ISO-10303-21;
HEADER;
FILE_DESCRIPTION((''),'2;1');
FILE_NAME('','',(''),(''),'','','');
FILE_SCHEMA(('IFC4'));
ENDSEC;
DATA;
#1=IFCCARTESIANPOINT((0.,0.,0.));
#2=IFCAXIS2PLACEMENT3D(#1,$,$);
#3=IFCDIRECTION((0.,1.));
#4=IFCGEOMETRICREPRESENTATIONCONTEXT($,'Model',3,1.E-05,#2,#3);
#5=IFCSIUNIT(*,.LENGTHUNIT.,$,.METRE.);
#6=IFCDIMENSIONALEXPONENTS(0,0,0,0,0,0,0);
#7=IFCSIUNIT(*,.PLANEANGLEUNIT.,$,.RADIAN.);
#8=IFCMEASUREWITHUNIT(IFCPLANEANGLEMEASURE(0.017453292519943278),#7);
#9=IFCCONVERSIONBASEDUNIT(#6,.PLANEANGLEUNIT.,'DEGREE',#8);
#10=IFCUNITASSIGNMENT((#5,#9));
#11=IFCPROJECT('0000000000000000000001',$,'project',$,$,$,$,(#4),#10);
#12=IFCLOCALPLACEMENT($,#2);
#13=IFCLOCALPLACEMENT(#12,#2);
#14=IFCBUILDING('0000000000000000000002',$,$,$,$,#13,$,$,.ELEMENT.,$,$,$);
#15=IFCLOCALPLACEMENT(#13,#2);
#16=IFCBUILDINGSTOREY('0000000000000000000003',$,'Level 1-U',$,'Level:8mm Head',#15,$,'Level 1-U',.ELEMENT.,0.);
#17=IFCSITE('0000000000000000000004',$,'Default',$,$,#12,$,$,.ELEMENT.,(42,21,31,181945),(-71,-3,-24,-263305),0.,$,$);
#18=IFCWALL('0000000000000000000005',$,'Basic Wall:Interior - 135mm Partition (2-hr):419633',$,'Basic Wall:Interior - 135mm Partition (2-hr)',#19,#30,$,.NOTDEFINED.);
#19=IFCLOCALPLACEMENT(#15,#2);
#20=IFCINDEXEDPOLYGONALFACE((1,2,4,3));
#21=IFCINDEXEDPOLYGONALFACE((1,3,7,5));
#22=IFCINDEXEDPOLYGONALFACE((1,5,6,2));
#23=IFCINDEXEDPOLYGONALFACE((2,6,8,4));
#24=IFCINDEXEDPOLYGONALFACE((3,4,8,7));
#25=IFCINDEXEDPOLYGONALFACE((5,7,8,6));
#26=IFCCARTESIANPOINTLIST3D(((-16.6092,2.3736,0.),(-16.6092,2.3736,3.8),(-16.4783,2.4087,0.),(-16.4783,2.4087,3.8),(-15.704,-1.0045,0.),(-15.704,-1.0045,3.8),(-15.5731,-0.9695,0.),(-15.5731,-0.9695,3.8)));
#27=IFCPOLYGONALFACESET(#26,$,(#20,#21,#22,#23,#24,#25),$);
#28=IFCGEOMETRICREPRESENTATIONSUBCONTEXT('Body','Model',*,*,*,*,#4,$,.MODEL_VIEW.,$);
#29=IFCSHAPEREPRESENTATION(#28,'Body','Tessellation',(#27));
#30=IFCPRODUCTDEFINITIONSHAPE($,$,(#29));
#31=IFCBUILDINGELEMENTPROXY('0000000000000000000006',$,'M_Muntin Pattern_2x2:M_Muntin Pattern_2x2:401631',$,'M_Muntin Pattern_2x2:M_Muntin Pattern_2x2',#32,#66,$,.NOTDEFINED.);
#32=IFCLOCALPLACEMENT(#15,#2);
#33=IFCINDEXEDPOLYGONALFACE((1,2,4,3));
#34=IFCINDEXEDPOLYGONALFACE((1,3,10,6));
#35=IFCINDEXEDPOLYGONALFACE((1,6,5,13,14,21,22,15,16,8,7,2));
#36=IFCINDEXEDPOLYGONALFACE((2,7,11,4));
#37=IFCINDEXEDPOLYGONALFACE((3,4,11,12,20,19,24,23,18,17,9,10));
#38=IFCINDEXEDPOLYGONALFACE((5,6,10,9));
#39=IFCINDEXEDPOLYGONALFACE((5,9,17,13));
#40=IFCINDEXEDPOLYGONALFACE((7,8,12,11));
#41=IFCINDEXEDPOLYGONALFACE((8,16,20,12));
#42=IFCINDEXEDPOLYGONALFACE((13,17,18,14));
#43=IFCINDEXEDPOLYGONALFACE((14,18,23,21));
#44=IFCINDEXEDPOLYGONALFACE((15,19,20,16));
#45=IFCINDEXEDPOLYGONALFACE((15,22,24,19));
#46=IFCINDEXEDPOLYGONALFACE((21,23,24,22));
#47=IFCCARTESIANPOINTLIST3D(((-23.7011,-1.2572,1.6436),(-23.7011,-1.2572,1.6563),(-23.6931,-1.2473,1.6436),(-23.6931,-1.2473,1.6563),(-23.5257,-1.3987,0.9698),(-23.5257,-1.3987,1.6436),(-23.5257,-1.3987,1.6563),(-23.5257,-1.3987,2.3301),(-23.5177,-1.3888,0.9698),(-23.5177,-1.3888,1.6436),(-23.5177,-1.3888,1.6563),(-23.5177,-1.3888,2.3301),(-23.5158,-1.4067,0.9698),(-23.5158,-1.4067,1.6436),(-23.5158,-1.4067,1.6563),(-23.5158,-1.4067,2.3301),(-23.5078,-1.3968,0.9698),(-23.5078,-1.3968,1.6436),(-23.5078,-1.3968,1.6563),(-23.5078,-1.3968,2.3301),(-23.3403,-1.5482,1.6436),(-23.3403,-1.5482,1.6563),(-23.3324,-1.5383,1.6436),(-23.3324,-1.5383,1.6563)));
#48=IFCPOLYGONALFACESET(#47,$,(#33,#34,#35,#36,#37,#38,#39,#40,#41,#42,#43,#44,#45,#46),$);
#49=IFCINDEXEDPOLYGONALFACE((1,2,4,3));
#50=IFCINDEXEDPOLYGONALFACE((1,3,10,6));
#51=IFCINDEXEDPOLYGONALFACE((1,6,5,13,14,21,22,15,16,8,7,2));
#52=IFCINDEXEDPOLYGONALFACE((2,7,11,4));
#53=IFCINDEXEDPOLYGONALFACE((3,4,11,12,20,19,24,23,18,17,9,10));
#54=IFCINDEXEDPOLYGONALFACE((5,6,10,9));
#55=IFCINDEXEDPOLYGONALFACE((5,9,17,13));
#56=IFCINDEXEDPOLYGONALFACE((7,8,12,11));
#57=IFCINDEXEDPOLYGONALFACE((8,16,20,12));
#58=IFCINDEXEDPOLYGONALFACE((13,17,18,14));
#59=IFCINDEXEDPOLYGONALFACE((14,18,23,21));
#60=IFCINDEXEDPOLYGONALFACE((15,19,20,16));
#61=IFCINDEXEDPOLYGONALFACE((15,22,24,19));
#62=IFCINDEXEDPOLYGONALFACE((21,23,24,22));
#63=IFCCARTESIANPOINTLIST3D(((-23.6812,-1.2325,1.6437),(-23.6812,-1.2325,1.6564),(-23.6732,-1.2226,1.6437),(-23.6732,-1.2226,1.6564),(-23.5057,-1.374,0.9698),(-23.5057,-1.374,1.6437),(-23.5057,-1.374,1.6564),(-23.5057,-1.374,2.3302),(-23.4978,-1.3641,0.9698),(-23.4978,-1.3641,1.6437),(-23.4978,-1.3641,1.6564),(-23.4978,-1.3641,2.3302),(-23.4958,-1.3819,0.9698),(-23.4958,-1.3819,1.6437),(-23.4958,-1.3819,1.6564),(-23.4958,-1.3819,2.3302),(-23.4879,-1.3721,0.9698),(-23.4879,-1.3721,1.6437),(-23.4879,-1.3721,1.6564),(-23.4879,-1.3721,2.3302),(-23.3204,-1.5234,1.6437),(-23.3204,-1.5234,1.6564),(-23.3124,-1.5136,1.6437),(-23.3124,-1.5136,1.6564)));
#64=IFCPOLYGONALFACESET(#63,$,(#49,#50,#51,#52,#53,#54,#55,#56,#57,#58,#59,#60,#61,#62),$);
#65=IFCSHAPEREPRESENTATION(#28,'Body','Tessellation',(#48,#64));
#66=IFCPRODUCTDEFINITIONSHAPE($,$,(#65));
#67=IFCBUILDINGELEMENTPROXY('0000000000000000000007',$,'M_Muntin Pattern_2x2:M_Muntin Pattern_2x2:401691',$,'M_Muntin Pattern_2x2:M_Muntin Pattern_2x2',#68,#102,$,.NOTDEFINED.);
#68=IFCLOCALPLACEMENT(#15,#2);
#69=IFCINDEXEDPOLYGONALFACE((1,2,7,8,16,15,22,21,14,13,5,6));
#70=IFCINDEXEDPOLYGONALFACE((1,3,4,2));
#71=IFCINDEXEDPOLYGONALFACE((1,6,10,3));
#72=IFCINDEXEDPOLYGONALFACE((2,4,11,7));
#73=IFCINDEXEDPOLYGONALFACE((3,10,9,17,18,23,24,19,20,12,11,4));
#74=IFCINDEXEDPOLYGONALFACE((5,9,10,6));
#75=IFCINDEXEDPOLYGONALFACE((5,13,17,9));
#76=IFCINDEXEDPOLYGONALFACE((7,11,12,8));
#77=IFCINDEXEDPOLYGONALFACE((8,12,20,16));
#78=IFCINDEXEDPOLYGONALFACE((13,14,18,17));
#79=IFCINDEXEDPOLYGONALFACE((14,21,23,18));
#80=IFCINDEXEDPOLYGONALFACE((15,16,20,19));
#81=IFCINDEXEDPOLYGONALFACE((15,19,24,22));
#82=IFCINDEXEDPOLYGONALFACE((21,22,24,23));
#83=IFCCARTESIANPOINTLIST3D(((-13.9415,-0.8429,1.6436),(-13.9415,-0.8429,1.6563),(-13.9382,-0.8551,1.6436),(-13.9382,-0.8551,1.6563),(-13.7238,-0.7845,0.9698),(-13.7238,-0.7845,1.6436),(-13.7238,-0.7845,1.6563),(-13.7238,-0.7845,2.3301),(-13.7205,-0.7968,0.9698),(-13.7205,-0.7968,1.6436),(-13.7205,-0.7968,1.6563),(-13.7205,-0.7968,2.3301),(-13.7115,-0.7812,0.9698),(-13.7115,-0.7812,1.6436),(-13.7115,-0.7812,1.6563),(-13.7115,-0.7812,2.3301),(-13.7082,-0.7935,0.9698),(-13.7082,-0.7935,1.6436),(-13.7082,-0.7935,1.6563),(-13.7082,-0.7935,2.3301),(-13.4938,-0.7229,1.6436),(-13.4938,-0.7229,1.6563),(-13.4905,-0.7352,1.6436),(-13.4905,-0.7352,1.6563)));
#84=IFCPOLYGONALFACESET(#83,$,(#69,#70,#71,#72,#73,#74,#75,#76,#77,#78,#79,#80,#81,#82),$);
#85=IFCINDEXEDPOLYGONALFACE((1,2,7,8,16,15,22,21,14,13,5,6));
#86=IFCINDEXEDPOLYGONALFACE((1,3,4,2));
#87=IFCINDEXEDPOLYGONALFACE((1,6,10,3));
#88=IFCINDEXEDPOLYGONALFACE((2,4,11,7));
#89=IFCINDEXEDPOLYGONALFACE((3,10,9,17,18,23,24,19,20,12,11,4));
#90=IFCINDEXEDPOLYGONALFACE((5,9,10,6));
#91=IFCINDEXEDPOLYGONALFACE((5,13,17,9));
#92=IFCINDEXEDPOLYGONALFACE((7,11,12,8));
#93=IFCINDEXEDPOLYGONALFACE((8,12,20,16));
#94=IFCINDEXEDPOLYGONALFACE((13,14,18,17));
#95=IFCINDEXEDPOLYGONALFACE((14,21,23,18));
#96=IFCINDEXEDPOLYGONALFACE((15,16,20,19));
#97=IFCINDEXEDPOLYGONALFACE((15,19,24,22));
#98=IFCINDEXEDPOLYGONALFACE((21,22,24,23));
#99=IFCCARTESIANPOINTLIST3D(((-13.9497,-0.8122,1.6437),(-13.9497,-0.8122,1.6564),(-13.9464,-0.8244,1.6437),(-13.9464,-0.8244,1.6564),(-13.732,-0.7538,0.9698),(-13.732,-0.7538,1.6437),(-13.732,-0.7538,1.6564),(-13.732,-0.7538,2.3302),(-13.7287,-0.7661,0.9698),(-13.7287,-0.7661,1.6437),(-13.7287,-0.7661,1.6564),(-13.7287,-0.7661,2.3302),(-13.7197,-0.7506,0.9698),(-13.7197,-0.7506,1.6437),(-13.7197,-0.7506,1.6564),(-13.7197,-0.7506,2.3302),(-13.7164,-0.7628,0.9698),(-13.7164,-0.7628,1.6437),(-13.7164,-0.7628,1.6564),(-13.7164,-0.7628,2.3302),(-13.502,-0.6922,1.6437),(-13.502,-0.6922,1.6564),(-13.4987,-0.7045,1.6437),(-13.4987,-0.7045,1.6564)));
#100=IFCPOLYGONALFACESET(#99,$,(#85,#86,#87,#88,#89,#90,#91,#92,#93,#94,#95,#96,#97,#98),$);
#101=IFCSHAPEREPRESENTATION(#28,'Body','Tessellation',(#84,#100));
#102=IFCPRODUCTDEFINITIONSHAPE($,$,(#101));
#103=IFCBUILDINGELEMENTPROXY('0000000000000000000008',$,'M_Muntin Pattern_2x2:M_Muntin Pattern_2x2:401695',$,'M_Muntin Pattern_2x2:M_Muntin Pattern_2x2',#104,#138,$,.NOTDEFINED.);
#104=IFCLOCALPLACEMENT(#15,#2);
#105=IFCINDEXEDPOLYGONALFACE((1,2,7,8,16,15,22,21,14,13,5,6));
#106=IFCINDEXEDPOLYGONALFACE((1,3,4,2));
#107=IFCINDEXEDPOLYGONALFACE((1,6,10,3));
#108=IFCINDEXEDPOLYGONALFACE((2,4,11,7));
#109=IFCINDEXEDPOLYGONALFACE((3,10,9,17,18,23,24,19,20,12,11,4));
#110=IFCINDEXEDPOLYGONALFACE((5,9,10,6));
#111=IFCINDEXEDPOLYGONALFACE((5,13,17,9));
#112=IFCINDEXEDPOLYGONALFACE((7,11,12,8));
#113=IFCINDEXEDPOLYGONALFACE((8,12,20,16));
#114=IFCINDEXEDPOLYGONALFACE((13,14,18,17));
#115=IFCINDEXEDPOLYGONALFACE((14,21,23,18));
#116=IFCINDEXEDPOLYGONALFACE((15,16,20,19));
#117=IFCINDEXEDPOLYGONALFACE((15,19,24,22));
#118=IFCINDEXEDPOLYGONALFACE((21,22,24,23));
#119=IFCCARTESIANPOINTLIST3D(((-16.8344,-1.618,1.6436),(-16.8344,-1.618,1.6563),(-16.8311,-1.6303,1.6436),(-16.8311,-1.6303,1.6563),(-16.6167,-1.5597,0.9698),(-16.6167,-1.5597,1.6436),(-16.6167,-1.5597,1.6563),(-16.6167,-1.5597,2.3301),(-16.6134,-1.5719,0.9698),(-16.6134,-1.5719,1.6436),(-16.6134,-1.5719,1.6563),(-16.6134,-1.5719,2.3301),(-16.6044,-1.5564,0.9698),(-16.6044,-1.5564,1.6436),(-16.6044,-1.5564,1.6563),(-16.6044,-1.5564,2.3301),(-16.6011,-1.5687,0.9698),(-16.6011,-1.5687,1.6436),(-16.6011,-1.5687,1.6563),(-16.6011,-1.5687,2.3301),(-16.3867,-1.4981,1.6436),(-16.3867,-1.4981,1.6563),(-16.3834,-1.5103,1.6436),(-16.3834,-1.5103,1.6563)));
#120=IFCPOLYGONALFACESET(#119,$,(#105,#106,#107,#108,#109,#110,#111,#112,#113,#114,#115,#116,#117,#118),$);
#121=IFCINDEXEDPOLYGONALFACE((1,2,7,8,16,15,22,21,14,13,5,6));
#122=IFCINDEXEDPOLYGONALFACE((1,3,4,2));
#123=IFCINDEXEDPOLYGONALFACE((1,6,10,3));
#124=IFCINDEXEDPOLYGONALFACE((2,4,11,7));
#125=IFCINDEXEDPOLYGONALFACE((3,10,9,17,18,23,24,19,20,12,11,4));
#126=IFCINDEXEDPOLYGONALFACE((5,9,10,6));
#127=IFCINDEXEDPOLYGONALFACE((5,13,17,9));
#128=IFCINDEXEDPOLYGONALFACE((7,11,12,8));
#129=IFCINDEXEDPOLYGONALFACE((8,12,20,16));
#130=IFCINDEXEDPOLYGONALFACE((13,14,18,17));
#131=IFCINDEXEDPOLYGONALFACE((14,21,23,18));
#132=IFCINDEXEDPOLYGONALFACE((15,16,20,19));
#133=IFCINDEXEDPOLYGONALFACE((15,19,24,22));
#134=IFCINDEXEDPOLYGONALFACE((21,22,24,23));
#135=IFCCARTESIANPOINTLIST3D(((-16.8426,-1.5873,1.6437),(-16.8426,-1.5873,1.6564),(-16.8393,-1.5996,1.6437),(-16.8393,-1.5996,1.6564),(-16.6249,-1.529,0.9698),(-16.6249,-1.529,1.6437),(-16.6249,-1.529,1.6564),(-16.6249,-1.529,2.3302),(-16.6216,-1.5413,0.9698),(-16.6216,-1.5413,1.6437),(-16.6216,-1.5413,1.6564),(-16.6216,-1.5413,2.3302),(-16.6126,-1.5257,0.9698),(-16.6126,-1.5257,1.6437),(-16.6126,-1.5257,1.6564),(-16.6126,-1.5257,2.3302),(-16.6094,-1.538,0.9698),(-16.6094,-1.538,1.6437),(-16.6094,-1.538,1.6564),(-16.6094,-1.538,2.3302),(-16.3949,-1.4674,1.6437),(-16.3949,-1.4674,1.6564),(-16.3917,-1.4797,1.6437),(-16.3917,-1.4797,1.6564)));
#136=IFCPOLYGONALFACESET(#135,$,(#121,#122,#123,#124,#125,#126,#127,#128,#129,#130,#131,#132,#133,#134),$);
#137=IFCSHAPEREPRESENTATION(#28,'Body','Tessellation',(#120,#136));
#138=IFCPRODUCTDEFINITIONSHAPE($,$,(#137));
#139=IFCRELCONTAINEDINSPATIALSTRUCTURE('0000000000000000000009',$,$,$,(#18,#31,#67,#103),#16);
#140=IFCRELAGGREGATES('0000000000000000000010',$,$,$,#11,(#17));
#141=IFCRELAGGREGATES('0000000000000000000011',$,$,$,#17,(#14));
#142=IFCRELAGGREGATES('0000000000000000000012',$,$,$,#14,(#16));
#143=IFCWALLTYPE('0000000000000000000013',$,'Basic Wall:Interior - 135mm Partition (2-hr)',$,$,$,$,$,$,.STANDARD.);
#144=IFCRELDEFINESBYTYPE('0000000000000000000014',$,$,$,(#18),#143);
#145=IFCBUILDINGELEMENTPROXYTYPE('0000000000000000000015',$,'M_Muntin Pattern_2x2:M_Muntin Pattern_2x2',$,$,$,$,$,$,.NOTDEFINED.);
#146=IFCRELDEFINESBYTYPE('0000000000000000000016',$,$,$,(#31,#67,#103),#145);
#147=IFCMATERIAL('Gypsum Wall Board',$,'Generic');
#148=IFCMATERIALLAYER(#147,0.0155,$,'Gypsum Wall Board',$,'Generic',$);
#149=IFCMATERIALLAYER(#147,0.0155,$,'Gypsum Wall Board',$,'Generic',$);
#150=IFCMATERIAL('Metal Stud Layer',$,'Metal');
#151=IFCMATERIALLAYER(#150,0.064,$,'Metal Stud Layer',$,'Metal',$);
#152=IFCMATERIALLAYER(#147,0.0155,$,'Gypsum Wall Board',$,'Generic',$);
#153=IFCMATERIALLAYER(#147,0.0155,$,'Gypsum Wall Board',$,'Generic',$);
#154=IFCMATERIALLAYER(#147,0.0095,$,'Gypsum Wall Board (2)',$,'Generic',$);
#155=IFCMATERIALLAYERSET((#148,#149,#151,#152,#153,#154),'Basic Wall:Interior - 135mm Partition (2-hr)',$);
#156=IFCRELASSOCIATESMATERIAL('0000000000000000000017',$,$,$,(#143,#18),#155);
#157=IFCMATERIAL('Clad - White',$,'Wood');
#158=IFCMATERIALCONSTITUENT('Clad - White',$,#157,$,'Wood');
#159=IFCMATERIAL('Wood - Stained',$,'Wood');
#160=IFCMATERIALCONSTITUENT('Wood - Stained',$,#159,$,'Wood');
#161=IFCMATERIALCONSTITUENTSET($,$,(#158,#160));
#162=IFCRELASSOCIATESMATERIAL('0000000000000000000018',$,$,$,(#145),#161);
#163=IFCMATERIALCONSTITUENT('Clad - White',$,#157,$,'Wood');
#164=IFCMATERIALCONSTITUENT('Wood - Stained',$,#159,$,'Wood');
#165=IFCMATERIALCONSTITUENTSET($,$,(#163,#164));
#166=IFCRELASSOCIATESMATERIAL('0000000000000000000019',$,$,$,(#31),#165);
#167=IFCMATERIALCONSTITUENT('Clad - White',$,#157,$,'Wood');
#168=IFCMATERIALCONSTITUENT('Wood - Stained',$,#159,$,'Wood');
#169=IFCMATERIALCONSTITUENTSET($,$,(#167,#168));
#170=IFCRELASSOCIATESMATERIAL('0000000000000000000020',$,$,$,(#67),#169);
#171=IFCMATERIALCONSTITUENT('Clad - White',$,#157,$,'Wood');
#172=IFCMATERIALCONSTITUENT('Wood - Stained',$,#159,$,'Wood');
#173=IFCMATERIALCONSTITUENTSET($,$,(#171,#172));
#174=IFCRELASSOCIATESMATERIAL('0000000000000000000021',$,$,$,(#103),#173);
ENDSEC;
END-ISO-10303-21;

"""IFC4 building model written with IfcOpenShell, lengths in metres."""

from ifc_helpers import new_model, entity, si_unit, converted_unit, direction, frame, frame_2d, origin, place, context, subcontext, project, spatial, polyline, rectangle, outline, extrude, source, transform, mapped, material, layer, layer_set, layer_usage, constituent, constituent_set, type_object, type_shapes, element, save


model = new_model("IFC4")

# Units and contexts
model_context = context("Model", 3, precision=1e-05, world=origin(), true_north=direction((0.0, 1.0)))
body_context = subcontext(model_context, "Body", "Model", "MODEL_VIEW")
ifc_project = project(units=[si_unit("LENGTHUNIT", "METRE"), converted_unit("PLANEANGLEUNIT", "DEGREE", entity("IfcPlaneAngleMeasure", 0.017453292519943278), si_unit("PLANEANGLEUNIT", "RADIAN"), dimensions=[0, 0, 0, 0, 0, 0, 0])], contexts=[model_context])

# Site, building, storey
site_placement = place(None, origin())
site = spatial("IfcSite", under=ifc_project, at=site_placement, Name="Default", CompositionType="ELEMENT", RefLatitude=(42, 21, 31, 181945), RefLongitude=(-71, -3, -24, -263305), RefElevation=0.0)
building_placement = place(site_placement, origin())
building = spatial("IfcBuilding", under=site, at=building_placement, CompositionType="ELEMENT")
storey_placement = place(building_placement, origin())
storey = spatial("IfcBuildingStorey", under=building, at=storey_placement, Name="Level 1-U", ObjectType="Level:8mm Head", LongName="Level 1-U", CompositionType="ELEMENT", Elevation=0.0)

# Wall
ifc_material_1 = material(Name="Gypsum Wall Board", Category="Generic")
ifc_layer_1 = layer(ifc_material_1, 0.0155, Name="Gypsum Wall Board", Category="Generic")
ifc_layer_2 = layer(ifc_material_1, 0.0155, Name="Gypsum Wall Board", Category="Generic")
ifc_material_2 = material(Name="Metal Stud Layer", Category="Metal")
ifc_layer_3 = layer(ifc_material_2, 0.064, Name="Metal Stud Layer", Category="Metal")
ifc_layer_4 = layer(ifc_material_1, 0.0155, Name="Gypsum Wall Board", Category="Generic")
ifc_layer_5 = layer(ifc_material_1, 0.0155, Name="Gypsum Wall Board", Category="Generic")
ifc_layer_6 = layer(ifc_material_1, 0.0095, Name="Gypsum Wall Board (2)", Category="Generic")
ifc_layer_set_1 = layer_set([ifc_layer_1, ifc_layer_2, ifc_layer_3, ifc_layer_4, ifc_layer_5, ifc_layer_6], Name="Basic Wall:Interior - 135mm Partition (2-hr)")
ifc_layer_usage_1 = layer_usage(ifc_layer_set_1, "AXIS2", "NEGATIVE", 0.0677)
wall_type_1 = type_object("IfcWallType", Name="Basic Wall:Interior - 135mm Partition (2-hr)", PredefinedType="STANDARD", material=ifc_layer_set_1)
wall_1_placement = place(storey_placement, frame((-16.5437, 2.3911, 0.0), z_axis=(0.0, 0.0, 1.0), x_axis=(0.258819, -0.965926, 0.0)))
element("IfcWall", 1, at=wall_1_placement, inside=storey, type_object=wall_type_1, material=ifc_layer_usage_1, Name="Basic Wall:Interior - 135mm Partition (2-hr):419633", ObjectType="Basic Wall:Interior - 135mm Partition (2-hr)", PredefinedType="NOTDEFINED", context=body_context, shape_type="SweptSolid", body=[
    extrude(rectangle(XDim=3.4973, YDim=0.1355, at=frame_2d((1.7487, 0.0), x_axis=(-1.0, 0.0))), origin(), (0.0, 0.0, 1.0), 3.8),
])

# Building element proxies
ifc_material_3 = material(Name="Clad - White", Category="Wood")
ifc_constituent_1 = constituent(ifc_material_3, Name="Clad - White", Category="Wood")
ifc_material_4 = material(Name="Wood - Stained", Category="Wood")
ifc_constituent_2 = constituent(ifc_material_4, Name="Wood - Stained", Category="Wood")
ifc_constituent_set_1 = constituent_set(constituents=[ifc_constituent_1, ifc_constituent_2])
ifc_constituent_3 = constituent(ifc_material_3, Name="Clad - White", Category="Wood")
ifc_constituent_4 = constituent(ifc_material_4, Name="Wood - Stained", Category="Wood")
ifc_constituent_set_2 = constituent_set(constituents=[ifc_constituent_3, ifc_constituent_4])
building_element_proxy_type_1 = type_object("IfcBuildingElementProxyType", Name="M_Muntin Pattern_2x2:M_Muntin Pattern_2x2", PredefinedType="NOTDEFINED", material=ifc_constituent_set_2)
shared_shape_1 = source(origin(), body_context, "Body", "SweptSolid", [
    extrude(outline(polyline([(0.0064, -0.0064), (0.6801, -0.0064), (0.6801, 0.0063), (0.0064, 0.0063), (0.0064, 0.2317), (-0.0063, 0.2317), (-0.0063, 0.0063), (-0.6802, 0.0063), (-0.6802, -0.0064), (-0.0063, -0.0064), (-0.0063, -0.2317), (0.0064, -0.2317), (0.0064, -0.0064)])), frame((0.0, 0.0095, 0.6801), z_axis=(0.0, 1.0, 0.0), x_axis=(0.0, 0.0, 1.0)), (0.0, 0.0, 1.0), 0.0127),
    extrude(outline(polyline([(0.0064, -0.0064), (0.6802, -0.0064), (0.6802, 0.0063), (0.0064, 0.0063), (0.0064, 0.2317), (-0.0063, 0.2317), (-0.0063, 0.0063), (-0.6802, 0.0063), (-0.6802, -0.0064), (-0.0063, -0.0064), (-0.0063, -0.2317), (0.0064, -0.2317), (0.0064, -0.0064)])), frame((0.0, -0.0222, 0.6802), z_axis=(0.0, 1.0, 0.0), x_axis=(0.0, 0.0, 1.0)), (0.0, 0.0, 1.0), 0.0127),
])
type_shapes(building_element_proxy_type_1, [shared_shape_1])
proxy_1_placement = place(storey_placement, frame((-23.5068, -1.3854, 0.9698), z_axis=(0.0, 0.0, 1.0), x_axis=(-0.778359, 0.62782, 0.0)))
element("IfcBuildingElementProxy", 2, at=proxy_1_placement, inside=storey, type_object=building_element_proxy_type_1, material=ifc_constituent_set_1, Name="M_Muntin Pattern_2x2:M_Muntin Pattern_2x2:401631", ObjectType="M_Muntin Pattern_2x2:M_Muntin Pattern_2x2", PredefinedType="NOTDEFINED", context=body_context, shape_type="MappedRepresentation", body=[
    mapped(shared_shape_1, transform((0.0, 0.0, 0.0), scale=1.0)),
])
ifc_constituent_5 = constituent(ifc_material_3, Name="Clad - White", Category="Wood")
ifc_constituent_6 = constituent(ifc_material_4, Name="Wood - Stained", Category="Wood")
ifc_constituent_set_3 = constituent_set(constituents=[ifc_constituent_5, ifc_constituent_6])
proxy_2_placement = place(storey_placement, frame((-13.7201, -0.7737, 0.9698), z_axis=(0.0, 0.0, 1.0), x_axis=(-0.965926, -0.258819, 0.0)))
element("IfcBuildingElementProxy", 3, at=proxy_2_placement, inside=storey, type_object=building_element_proxy_type_1, material=ifc_constituent_set_3, Name="M_Muntin Pattern_2x2:M_Muntin Pattern_2x2:401691", ObjectType="M_Muntin Pattern_2x2:M_Muntin Pattern_2x2", PredefinedType="NOTDEFINED", context=body_context, shape_type="MappedRepresentation", body=[
    mapped(shared_shape_1, transform((0.0, 0.0, 0.0), scale=1.0)),
])
ifc_constituent_7 = constituent(ifc_material_3, Name="Clad - White", Category="Wood")
ifc_constituent_8 = constituent(ifc_material_4, Name="Wood - Stained", Category="Wood")
ifc_constituent_set_4 = constituent_set(constituents=[ifc_constituent_7, ifc_constituent_8])
proxy_3_placement = place(storey_placement, frame((-16.613, -1.5488, 0.9698), z_axis=(0.0, 0.0, 1.0), x_axis=(-0.965926, -0.258819, 0.0)))
element("IfcBuildingElementProxy", 4, at=proxy_3_placement, inside=storey, type_object=building_element_proxy_type_1, material=ifc_constituent_set_4, Name="M_Muntin Pattern_2x2:M_Muntin Pattern_2x2:401695", ObjectType="M_Muntin Pattern_2x2:M_Muntin Pattern_2x2", PredefinedType="NOTDEFINED", context=body_context, shape_type="MappedRepresentation", body=[
    mapped(shared_shape_1, transform((0.0, 0.0, 0.0), scale=1.0)),
])

save(model, "model.ifc")
